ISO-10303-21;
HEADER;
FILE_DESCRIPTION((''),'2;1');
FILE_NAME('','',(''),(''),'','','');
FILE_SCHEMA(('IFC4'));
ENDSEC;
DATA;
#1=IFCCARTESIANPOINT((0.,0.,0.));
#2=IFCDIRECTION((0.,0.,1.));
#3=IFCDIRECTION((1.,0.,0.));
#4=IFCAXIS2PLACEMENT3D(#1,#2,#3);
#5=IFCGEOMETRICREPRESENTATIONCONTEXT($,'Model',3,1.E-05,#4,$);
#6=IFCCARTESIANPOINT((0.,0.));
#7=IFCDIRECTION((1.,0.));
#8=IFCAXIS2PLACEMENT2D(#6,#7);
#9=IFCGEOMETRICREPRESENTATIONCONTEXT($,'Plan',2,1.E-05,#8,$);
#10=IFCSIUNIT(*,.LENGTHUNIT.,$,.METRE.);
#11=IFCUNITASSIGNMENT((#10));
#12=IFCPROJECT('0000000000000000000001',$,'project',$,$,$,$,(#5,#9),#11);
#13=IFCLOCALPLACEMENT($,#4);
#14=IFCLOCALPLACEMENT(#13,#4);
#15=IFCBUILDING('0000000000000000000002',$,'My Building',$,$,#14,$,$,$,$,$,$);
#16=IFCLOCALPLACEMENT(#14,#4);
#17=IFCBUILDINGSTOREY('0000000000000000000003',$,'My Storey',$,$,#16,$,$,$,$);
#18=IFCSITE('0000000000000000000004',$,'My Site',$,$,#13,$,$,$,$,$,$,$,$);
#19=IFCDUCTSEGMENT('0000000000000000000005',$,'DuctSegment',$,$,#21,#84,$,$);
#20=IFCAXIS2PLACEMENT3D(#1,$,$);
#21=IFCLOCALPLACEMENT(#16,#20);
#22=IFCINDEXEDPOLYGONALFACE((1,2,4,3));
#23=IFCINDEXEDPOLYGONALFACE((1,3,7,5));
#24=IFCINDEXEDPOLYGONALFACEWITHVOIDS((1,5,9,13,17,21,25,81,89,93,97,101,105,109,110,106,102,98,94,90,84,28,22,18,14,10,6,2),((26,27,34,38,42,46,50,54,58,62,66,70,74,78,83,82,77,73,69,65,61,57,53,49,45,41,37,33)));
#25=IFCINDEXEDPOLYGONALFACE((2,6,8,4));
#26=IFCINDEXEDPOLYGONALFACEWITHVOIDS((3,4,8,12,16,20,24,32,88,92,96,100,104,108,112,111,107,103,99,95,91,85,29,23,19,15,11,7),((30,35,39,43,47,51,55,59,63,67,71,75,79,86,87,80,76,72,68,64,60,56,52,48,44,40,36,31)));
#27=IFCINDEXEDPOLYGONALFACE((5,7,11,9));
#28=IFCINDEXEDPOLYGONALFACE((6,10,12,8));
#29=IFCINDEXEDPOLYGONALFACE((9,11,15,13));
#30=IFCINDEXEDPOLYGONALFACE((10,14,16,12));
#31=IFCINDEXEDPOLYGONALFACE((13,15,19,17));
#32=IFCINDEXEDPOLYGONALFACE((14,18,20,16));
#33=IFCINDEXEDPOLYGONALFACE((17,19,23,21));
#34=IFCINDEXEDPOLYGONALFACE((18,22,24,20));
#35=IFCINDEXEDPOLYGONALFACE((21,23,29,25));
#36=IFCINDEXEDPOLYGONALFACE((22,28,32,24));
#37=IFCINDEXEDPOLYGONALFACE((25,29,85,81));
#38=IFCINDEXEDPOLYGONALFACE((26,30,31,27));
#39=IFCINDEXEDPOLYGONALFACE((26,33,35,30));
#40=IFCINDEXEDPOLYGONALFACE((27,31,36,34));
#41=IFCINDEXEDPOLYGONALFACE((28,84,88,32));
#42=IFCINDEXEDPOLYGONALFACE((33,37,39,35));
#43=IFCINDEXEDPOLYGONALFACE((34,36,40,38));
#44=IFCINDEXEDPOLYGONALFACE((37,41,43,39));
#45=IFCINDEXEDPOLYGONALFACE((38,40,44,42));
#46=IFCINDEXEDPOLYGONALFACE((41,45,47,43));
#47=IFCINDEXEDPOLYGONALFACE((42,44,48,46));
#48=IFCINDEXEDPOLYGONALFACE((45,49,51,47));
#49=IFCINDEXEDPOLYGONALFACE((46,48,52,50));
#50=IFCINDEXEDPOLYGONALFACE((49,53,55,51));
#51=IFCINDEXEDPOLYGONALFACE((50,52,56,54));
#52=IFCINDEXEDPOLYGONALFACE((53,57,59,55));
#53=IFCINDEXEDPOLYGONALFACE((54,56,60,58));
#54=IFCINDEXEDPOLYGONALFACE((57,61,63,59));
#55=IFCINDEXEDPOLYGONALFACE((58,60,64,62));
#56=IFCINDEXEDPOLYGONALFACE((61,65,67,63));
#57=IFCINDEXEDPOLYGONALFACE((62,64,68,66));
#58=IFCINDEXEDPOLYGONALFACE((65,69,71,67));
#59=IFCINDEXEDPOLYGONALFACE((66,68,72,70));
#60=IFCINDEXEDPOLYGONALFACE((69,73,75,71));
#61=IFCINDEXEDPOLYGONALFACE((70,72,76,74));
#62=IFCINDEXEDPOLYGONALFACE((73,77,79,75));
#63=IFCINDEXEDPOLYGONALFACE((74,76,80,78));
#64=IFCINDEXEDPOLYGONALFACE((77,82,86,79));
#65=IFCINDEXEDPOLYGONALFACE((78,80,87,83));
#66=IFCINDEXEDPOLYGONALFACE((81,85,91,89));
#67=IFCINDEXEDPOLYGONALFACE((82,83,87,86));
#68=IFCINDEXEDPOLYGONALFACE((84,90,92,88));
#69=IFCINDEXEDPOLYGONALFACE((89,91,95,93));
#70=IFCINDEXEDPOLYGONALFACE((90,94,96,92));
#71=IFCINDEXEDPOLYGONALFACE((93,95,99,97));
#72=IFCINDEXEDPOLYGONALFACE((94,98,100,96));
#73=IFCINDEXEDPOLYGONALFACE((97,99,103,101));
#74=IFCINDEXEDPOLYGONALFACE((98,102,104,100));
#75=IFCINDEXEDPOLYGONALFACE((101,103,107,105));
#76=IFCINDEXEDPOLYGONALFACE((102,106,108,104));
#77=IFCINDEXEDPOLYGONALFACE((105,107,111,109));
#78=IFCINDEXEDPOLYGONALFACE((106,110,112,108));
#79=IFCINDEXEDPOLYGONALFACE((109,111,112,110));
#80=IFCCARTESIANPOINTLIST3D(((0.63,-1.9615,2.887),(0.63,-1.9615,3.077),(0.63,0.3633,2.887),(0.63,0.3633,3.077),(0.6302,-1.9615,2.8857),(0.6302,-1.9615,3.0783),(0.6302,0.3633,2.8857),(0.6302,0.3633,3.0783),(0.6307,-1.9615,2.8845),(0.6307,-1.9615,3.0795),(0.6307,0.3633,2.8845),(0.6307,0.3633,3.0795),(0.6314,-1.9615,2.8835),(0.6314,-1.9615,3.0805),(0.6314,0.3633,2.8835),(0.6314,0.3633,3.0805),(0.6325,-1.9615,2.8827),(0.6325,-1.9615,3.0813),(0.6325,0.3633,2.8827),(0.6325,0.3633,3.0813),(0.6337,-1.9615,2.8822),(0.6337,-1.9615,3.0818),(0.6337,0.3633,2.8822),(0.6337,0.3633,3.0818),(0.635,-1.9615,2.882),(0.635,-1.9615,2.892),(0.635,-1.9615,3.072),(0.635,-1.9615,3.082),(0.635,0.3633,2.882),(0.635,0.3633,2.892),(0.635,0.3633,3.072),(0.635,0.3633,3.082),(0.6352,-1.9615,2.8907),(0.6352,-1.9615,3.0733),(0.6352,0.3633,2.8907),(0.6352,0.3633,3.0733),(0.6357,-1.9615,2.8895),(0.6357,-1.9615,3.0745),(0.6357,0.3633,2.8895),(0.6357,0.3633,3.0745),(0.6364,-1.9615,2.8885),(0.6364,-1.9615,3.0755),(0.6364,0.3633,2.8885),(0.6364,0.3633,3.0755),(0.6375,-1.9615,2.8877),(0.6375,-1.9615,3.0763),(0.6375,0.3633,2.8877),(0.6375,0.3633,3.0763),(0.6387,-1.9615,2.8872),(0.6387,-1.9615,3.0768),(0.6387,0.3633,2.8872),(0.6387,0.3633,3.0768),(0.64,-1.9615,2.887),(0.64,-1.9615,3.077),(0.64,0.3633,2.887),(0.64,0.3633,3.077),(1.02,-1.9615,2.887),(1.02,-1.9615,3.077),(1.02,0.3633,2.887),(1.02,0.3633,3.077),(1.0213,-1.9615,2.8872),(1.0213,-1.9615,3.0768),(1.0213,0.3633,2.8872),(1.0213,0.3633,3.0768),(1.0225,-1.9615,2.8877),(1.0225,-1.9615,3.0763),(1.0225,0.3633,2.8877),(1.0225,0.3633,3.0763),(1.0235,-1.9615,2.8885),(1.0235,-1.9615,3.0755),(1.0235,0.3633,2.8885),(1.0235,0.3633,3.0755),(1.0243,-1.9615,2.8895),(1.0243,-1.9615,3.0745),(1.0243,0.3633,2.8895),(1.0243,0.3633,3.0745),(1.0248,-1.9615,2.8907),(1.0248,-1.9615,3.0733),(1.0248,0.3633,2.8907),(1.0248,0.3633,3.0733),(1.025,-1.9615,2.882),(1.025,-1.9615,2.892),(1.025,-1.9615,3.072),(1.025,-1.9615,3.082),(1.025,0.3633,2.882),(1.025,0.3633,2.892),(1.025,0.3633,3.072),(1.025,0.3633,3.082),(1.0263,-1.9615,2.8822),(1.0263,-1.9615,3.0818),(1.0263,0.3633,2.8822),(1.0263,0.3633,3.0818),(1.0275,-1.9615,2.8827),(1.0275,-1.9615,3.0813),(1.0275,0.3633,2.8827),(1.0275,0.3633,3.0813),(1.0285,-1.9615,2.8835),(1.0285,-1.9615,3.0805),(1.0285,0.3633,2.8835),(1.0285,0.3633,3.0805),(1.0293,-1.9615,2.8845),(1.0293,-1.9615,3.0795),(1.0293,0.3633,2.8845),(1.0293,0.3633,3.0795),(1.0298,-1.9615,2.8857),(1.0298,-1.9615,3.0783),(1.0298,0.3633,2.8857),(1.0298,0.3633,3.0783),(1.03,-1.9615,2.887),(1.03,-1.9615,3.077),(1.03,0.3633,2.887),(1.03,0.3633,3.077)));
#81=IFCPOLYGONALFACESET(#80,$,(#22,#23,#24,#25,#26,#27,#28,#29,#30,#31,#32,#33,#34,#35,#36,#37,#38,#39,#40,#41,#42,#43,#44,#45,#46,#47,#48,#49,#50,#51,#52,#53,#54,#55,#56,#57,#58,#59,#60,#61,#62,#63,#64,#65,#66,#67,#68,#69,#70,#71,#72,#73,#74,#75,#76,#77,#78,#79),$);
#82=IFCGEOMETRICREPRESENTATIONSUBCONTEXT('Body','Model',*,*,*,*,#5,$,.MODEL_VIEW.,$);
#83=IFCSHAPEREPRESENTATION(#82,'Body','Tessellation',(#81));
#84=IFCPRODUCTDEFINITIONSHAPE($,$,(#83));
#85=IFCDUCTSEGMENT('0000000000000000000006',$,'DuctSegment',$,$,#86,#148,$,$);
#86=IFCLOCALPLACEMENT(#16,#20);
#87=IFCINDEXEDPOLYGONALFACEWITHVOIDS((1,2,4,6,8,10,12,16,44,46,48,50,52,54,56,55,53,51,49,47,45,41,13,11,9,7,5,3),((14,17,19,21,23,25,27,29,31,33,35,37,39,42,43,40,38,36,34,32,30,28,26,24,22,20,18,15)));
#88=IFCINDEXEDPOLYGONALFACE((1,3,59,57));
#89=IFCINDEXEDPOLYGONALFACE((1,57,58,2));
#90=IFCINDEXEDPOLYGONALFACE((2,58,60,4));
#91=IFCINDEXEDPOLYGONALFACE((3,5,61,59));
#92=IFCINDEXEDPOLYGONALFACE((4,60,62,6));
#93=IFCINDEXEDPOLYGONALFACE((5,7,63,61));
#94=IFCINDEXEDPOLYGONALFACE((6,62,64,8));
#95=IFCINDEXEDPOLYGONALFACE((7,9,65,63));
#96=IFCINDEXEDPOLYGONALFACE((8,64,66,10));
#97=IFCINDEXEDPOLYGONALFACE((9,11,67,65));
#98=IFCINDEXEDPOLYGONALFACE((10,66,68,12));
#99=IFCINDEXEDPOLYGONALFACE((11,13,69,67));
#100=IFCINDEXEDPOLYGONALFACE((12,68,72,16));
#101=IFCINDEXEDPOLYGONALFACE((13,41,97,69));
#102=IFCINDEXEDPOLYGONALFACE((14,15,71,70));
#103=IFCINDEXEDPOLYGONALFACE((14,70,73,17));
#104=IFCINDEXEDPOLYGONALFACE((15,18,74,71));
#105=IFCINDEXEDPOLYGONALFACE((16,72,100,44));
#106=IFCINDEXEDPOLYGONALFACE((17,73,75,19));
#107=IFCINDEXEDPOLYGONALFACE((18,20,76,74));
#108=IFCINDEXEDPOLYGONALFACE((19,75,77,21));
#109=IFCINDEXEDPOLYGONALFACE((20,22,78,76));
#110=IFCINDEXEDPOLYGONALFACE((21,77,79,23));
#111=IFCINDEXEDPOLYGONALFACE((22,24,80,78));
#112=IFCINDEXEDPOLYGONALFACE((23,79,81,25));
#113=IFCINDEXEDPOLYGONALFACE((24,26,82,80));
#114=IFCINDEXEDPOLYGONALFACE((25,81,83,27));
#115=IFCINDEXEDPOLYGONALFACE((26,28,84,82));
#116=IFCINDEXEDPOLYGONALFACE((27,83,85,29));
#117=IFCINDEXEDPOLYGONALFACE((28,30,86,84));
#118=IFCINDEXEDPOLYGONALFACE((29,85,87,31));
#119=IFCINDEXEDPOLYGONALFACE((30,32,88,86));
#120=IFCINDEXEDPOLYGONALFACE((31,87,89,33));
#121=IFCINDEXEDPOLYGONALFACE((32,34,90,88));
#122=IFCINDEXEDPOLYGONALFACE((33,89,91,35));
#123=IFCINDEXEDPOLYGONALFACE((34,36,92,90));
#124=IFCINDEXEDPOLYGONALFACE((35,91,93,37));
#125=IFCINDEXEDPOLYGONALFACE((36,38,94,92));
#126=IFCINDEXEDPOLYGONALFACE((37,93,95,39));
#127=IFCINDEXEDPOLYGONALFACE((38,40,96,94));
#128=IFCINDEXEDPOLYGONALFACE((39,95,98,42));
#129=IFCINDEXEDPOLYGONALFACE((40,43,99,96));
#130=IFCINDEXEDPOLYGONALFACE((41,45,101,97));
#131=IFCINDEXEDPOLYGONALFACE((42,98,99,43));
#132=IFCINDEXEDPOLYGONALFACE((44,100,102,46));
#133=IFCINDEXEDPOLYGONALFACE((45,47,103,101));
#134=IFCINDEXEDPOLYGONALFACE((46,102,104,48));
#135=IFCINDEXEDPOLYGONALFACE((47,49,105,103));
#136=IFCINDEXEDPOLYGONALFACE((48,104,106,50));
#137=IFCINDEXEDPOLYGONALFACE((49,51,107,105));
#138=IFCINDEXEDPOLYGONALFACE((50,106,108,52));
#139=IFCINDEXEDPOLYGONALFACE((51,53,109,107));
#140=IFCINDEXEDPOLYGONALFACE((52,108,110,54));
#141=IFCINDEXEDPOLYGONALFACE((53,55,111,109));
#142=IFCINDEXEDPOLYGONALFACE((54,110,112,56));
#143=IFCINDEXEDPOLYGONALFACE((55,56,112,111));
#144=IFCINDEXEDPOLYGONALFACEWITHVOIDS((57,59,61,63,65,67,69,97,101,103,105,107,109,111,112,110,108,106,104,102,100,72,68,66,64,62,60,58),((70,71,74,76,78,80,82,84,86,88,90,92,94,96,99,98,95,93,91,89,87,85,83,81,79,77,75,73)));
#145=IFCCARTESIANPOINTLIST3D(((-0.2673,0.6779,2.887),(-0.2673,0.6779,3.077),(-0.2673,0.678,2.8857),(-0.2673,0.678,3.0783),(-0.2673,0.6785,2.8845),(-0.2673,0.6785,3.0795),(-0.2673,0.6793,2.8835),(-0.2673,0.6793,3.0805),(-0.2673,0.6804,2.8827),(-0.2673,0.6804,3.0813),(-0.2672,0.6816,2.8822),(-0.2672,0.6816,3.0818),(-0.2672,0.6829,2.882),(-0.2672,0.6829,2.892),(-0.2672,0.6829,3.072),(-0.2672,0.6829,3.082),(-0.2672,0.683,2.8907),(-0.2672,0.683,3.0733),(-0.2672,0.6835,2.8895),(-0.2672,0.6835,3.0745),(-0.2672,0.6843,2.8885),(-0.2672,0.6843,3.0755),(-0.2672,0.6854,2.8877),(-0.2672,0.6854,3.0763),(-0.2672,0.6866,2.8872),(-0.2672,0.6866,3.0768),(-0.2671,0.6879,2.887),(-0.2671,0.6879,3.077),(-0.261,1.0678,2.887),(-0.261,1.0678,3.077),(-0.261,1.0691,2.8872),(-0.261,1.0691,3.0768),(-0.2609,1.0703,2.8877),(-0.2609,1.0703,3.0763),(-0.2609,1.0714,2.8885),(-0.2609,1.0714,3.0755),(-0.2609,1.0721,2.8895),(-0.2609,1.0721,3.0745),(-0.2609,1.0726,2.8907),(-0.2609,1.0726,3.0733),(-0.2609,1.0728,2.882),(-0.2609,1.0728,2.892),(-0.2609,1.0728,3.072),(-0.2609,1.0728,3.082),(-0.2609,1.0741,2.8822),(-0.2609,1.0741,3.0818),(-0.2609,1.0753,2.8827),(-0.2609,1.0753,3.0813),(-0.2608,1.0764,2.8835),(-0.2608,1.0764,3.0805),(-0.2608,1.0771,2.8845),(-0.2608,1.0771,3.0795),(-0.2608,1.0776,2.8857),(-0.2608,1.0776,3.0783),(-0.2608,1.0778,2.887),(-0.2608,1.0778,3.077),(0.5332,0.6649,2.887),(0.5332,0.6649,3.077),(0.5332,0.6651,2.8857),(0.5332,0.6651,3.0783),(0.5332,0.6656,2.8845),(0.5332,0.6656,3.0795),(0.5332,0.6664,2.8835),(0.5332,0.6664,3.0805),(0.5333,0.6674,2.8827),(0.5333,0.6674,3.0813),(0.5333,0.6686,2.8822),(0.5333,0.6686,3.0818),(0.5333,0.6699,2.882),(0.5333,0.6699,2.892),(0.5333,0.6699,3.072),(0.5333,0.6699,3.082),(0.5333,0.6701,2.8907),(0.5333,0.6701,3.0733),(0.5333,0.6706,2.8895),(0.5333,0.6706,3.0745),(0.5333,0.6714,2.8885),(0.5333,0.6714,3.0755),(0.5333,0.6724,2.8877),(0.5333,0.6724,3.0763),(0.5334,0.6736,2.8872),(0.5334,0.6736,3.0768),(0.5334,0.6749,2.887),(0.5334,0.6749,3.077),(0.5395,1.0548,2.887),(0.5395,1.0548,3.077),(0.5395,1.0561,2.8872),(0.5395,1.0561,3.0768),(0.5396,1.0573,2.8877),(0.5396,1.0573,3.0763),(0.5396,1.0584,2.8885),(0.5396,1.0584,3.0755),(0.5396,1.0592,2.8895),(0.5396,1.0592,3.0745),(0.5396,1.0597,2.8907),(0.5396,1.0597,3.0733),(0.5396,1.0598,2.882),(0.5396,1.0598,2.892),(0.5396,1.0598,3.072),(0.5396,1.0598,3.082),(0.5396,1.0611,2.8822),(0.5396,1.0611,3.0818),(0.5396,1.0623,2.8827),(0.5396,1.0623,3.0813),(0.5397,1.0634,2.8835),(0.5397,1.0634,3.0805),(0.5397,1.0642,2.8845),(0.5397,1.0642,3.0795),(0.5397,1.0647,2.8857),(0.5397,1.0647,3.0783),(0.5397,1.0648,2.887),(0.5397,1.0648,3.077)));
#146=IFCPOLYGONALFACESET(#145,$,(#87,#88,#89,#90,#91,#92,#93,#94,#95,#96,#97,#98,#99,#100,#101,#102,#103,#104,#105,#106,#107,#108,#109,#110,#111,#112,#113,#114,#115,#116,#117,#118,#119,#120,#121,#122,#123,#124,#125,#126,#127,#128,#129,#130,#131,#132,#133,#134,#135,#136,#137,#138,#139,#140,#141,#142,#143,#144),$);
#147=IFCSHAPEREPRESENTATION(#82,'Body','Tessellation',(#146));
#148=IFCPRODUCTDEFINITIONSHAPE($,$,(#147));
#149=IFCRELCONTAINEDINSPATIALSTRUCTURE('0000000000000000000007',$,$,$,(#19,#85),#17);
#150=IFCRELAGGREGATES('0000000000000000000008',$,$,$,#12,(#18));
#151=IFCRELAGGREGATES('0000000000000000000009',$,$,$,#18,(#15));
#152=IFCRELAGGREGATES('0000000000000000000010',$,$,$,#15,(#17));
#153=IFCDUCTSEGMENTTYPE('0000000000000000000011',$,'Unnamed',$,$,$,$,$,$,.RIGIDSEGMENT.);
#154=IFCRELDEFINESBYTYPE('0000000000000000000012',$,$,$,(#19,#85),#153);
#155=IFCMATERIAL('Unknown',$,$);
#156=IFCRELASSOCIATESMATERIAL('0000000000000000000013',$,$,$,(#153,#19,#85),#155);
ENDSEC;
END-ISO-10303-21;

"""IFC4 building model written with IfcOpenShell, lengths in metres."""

from ifc_helpers import new_model, si_unit, frame, origin_with_axes, origin_2d_with_axis, place, context, subcontext, project, spatial, hollow_rectangle, extrude, material, material_profile, profile_set, profile_usage, type_object, element, save


model = new_model("IFC4")

# Units and contexts
model_context = context("Model", 3, precision=1e-05, world=origin_with_axes())
plan_context = context("Plan", 2, precision=1e-05, world=origin_2d_with_axis())
body_context_1 = subcontext(model_context, "Body", "Model", "MODEL_VIEW")
ifc_project = project(units=[si_unit("LENGTHUNIT", "METRE")], contexts=[model_context, plan_context])

# Site, building, storey
site_placement = place(None, origin_with_axes())
site = spatial("IfcSite", under=ifc_project, at=site_placement, Name="My Site")
building_placement = place(site_placement, origin_with_axes())
building = spatial("IfcBuilding", under=site, at=building_placement, Name="My Building")
storey_placement = place(building_placement, origin_with_axes())
storey = spatial("IfcBuildingStorey", under=building, at=storey_placement, Name="My Storey")

# Shared definitions
ifc_material = material(Name="Unknown")

# Duct segments
ifc_material_profile_1 = material_profile(ifc_material, hollow_rectangle(XDim=0.4, YDim=0.2, WallThickness=0.005, InnerFilletRadius=0.005, OuterFilletRadius=0.005))
ifc_profile_set_1 = profile_set([ifc_material_profile_1])
ifc_profile_usage_1 = profile_usage(ifc_profile_set_1, cardinal=5)
duct_segment_type_1 = type_object("IfcDuctSegmentType", Name="Unnamed", PredefinedType="RIGIDSEGMENT", material=ifc_profile_set_1)
duct_segment_1_placement = place(storey_placement, frame((0.83, 0.3633, 2.982), z_axis=(0.0, -1.0, 0.0), x_axis=(1.0, 0.0, 0.0)))
element("IfcDuctSegment", 1, at=duct_segment_1_placement, inside=storey, type_object=duct_segment_type_1, material=ifc_profile_usage_1, Name="DuctSegment", context=body_context_1, shape_type="SweptSolid", body=[
    extrude(hollow_rectangle(XDim=0.4, YDim=0.2, WallThickness=0.005, InnerFilletRadius=0.005, OuterFilletRadius=0.005), origin_with_axes(), (0.0, 0.0, 1.0), 2.3248),
])
ifc_profile_usage_2 = profile_usage(ifc_profile_set_1, cardinal=5)
duct_segment_2_placement = place(storey_placement, frame((0.5364, 0.8649, 2.982), z_axis=(-0.999869, 0.016199, 0.0), x_axis=(-0.016199, -0.999869, 0.0)))
element("IfcDuctSegment", 2, at=duct_segment_2_placement, inside=storey, type_object=duct_segment_type_1, material=ifc_profile_usage_2, Name="DuctSegment", context=body_context_1, shape_type="SweptSolid", body=[
    extrude(hollow_rectangle(XDim=0.4, YDim=0.2, WallThickness=0.005, InnerFilletRadius=0.005, OuterFilletRadius=0.005), origin_with_axes(), (0.0, 0.0, 1.0), 0.8006),
])

save(model, "model.ifc")
